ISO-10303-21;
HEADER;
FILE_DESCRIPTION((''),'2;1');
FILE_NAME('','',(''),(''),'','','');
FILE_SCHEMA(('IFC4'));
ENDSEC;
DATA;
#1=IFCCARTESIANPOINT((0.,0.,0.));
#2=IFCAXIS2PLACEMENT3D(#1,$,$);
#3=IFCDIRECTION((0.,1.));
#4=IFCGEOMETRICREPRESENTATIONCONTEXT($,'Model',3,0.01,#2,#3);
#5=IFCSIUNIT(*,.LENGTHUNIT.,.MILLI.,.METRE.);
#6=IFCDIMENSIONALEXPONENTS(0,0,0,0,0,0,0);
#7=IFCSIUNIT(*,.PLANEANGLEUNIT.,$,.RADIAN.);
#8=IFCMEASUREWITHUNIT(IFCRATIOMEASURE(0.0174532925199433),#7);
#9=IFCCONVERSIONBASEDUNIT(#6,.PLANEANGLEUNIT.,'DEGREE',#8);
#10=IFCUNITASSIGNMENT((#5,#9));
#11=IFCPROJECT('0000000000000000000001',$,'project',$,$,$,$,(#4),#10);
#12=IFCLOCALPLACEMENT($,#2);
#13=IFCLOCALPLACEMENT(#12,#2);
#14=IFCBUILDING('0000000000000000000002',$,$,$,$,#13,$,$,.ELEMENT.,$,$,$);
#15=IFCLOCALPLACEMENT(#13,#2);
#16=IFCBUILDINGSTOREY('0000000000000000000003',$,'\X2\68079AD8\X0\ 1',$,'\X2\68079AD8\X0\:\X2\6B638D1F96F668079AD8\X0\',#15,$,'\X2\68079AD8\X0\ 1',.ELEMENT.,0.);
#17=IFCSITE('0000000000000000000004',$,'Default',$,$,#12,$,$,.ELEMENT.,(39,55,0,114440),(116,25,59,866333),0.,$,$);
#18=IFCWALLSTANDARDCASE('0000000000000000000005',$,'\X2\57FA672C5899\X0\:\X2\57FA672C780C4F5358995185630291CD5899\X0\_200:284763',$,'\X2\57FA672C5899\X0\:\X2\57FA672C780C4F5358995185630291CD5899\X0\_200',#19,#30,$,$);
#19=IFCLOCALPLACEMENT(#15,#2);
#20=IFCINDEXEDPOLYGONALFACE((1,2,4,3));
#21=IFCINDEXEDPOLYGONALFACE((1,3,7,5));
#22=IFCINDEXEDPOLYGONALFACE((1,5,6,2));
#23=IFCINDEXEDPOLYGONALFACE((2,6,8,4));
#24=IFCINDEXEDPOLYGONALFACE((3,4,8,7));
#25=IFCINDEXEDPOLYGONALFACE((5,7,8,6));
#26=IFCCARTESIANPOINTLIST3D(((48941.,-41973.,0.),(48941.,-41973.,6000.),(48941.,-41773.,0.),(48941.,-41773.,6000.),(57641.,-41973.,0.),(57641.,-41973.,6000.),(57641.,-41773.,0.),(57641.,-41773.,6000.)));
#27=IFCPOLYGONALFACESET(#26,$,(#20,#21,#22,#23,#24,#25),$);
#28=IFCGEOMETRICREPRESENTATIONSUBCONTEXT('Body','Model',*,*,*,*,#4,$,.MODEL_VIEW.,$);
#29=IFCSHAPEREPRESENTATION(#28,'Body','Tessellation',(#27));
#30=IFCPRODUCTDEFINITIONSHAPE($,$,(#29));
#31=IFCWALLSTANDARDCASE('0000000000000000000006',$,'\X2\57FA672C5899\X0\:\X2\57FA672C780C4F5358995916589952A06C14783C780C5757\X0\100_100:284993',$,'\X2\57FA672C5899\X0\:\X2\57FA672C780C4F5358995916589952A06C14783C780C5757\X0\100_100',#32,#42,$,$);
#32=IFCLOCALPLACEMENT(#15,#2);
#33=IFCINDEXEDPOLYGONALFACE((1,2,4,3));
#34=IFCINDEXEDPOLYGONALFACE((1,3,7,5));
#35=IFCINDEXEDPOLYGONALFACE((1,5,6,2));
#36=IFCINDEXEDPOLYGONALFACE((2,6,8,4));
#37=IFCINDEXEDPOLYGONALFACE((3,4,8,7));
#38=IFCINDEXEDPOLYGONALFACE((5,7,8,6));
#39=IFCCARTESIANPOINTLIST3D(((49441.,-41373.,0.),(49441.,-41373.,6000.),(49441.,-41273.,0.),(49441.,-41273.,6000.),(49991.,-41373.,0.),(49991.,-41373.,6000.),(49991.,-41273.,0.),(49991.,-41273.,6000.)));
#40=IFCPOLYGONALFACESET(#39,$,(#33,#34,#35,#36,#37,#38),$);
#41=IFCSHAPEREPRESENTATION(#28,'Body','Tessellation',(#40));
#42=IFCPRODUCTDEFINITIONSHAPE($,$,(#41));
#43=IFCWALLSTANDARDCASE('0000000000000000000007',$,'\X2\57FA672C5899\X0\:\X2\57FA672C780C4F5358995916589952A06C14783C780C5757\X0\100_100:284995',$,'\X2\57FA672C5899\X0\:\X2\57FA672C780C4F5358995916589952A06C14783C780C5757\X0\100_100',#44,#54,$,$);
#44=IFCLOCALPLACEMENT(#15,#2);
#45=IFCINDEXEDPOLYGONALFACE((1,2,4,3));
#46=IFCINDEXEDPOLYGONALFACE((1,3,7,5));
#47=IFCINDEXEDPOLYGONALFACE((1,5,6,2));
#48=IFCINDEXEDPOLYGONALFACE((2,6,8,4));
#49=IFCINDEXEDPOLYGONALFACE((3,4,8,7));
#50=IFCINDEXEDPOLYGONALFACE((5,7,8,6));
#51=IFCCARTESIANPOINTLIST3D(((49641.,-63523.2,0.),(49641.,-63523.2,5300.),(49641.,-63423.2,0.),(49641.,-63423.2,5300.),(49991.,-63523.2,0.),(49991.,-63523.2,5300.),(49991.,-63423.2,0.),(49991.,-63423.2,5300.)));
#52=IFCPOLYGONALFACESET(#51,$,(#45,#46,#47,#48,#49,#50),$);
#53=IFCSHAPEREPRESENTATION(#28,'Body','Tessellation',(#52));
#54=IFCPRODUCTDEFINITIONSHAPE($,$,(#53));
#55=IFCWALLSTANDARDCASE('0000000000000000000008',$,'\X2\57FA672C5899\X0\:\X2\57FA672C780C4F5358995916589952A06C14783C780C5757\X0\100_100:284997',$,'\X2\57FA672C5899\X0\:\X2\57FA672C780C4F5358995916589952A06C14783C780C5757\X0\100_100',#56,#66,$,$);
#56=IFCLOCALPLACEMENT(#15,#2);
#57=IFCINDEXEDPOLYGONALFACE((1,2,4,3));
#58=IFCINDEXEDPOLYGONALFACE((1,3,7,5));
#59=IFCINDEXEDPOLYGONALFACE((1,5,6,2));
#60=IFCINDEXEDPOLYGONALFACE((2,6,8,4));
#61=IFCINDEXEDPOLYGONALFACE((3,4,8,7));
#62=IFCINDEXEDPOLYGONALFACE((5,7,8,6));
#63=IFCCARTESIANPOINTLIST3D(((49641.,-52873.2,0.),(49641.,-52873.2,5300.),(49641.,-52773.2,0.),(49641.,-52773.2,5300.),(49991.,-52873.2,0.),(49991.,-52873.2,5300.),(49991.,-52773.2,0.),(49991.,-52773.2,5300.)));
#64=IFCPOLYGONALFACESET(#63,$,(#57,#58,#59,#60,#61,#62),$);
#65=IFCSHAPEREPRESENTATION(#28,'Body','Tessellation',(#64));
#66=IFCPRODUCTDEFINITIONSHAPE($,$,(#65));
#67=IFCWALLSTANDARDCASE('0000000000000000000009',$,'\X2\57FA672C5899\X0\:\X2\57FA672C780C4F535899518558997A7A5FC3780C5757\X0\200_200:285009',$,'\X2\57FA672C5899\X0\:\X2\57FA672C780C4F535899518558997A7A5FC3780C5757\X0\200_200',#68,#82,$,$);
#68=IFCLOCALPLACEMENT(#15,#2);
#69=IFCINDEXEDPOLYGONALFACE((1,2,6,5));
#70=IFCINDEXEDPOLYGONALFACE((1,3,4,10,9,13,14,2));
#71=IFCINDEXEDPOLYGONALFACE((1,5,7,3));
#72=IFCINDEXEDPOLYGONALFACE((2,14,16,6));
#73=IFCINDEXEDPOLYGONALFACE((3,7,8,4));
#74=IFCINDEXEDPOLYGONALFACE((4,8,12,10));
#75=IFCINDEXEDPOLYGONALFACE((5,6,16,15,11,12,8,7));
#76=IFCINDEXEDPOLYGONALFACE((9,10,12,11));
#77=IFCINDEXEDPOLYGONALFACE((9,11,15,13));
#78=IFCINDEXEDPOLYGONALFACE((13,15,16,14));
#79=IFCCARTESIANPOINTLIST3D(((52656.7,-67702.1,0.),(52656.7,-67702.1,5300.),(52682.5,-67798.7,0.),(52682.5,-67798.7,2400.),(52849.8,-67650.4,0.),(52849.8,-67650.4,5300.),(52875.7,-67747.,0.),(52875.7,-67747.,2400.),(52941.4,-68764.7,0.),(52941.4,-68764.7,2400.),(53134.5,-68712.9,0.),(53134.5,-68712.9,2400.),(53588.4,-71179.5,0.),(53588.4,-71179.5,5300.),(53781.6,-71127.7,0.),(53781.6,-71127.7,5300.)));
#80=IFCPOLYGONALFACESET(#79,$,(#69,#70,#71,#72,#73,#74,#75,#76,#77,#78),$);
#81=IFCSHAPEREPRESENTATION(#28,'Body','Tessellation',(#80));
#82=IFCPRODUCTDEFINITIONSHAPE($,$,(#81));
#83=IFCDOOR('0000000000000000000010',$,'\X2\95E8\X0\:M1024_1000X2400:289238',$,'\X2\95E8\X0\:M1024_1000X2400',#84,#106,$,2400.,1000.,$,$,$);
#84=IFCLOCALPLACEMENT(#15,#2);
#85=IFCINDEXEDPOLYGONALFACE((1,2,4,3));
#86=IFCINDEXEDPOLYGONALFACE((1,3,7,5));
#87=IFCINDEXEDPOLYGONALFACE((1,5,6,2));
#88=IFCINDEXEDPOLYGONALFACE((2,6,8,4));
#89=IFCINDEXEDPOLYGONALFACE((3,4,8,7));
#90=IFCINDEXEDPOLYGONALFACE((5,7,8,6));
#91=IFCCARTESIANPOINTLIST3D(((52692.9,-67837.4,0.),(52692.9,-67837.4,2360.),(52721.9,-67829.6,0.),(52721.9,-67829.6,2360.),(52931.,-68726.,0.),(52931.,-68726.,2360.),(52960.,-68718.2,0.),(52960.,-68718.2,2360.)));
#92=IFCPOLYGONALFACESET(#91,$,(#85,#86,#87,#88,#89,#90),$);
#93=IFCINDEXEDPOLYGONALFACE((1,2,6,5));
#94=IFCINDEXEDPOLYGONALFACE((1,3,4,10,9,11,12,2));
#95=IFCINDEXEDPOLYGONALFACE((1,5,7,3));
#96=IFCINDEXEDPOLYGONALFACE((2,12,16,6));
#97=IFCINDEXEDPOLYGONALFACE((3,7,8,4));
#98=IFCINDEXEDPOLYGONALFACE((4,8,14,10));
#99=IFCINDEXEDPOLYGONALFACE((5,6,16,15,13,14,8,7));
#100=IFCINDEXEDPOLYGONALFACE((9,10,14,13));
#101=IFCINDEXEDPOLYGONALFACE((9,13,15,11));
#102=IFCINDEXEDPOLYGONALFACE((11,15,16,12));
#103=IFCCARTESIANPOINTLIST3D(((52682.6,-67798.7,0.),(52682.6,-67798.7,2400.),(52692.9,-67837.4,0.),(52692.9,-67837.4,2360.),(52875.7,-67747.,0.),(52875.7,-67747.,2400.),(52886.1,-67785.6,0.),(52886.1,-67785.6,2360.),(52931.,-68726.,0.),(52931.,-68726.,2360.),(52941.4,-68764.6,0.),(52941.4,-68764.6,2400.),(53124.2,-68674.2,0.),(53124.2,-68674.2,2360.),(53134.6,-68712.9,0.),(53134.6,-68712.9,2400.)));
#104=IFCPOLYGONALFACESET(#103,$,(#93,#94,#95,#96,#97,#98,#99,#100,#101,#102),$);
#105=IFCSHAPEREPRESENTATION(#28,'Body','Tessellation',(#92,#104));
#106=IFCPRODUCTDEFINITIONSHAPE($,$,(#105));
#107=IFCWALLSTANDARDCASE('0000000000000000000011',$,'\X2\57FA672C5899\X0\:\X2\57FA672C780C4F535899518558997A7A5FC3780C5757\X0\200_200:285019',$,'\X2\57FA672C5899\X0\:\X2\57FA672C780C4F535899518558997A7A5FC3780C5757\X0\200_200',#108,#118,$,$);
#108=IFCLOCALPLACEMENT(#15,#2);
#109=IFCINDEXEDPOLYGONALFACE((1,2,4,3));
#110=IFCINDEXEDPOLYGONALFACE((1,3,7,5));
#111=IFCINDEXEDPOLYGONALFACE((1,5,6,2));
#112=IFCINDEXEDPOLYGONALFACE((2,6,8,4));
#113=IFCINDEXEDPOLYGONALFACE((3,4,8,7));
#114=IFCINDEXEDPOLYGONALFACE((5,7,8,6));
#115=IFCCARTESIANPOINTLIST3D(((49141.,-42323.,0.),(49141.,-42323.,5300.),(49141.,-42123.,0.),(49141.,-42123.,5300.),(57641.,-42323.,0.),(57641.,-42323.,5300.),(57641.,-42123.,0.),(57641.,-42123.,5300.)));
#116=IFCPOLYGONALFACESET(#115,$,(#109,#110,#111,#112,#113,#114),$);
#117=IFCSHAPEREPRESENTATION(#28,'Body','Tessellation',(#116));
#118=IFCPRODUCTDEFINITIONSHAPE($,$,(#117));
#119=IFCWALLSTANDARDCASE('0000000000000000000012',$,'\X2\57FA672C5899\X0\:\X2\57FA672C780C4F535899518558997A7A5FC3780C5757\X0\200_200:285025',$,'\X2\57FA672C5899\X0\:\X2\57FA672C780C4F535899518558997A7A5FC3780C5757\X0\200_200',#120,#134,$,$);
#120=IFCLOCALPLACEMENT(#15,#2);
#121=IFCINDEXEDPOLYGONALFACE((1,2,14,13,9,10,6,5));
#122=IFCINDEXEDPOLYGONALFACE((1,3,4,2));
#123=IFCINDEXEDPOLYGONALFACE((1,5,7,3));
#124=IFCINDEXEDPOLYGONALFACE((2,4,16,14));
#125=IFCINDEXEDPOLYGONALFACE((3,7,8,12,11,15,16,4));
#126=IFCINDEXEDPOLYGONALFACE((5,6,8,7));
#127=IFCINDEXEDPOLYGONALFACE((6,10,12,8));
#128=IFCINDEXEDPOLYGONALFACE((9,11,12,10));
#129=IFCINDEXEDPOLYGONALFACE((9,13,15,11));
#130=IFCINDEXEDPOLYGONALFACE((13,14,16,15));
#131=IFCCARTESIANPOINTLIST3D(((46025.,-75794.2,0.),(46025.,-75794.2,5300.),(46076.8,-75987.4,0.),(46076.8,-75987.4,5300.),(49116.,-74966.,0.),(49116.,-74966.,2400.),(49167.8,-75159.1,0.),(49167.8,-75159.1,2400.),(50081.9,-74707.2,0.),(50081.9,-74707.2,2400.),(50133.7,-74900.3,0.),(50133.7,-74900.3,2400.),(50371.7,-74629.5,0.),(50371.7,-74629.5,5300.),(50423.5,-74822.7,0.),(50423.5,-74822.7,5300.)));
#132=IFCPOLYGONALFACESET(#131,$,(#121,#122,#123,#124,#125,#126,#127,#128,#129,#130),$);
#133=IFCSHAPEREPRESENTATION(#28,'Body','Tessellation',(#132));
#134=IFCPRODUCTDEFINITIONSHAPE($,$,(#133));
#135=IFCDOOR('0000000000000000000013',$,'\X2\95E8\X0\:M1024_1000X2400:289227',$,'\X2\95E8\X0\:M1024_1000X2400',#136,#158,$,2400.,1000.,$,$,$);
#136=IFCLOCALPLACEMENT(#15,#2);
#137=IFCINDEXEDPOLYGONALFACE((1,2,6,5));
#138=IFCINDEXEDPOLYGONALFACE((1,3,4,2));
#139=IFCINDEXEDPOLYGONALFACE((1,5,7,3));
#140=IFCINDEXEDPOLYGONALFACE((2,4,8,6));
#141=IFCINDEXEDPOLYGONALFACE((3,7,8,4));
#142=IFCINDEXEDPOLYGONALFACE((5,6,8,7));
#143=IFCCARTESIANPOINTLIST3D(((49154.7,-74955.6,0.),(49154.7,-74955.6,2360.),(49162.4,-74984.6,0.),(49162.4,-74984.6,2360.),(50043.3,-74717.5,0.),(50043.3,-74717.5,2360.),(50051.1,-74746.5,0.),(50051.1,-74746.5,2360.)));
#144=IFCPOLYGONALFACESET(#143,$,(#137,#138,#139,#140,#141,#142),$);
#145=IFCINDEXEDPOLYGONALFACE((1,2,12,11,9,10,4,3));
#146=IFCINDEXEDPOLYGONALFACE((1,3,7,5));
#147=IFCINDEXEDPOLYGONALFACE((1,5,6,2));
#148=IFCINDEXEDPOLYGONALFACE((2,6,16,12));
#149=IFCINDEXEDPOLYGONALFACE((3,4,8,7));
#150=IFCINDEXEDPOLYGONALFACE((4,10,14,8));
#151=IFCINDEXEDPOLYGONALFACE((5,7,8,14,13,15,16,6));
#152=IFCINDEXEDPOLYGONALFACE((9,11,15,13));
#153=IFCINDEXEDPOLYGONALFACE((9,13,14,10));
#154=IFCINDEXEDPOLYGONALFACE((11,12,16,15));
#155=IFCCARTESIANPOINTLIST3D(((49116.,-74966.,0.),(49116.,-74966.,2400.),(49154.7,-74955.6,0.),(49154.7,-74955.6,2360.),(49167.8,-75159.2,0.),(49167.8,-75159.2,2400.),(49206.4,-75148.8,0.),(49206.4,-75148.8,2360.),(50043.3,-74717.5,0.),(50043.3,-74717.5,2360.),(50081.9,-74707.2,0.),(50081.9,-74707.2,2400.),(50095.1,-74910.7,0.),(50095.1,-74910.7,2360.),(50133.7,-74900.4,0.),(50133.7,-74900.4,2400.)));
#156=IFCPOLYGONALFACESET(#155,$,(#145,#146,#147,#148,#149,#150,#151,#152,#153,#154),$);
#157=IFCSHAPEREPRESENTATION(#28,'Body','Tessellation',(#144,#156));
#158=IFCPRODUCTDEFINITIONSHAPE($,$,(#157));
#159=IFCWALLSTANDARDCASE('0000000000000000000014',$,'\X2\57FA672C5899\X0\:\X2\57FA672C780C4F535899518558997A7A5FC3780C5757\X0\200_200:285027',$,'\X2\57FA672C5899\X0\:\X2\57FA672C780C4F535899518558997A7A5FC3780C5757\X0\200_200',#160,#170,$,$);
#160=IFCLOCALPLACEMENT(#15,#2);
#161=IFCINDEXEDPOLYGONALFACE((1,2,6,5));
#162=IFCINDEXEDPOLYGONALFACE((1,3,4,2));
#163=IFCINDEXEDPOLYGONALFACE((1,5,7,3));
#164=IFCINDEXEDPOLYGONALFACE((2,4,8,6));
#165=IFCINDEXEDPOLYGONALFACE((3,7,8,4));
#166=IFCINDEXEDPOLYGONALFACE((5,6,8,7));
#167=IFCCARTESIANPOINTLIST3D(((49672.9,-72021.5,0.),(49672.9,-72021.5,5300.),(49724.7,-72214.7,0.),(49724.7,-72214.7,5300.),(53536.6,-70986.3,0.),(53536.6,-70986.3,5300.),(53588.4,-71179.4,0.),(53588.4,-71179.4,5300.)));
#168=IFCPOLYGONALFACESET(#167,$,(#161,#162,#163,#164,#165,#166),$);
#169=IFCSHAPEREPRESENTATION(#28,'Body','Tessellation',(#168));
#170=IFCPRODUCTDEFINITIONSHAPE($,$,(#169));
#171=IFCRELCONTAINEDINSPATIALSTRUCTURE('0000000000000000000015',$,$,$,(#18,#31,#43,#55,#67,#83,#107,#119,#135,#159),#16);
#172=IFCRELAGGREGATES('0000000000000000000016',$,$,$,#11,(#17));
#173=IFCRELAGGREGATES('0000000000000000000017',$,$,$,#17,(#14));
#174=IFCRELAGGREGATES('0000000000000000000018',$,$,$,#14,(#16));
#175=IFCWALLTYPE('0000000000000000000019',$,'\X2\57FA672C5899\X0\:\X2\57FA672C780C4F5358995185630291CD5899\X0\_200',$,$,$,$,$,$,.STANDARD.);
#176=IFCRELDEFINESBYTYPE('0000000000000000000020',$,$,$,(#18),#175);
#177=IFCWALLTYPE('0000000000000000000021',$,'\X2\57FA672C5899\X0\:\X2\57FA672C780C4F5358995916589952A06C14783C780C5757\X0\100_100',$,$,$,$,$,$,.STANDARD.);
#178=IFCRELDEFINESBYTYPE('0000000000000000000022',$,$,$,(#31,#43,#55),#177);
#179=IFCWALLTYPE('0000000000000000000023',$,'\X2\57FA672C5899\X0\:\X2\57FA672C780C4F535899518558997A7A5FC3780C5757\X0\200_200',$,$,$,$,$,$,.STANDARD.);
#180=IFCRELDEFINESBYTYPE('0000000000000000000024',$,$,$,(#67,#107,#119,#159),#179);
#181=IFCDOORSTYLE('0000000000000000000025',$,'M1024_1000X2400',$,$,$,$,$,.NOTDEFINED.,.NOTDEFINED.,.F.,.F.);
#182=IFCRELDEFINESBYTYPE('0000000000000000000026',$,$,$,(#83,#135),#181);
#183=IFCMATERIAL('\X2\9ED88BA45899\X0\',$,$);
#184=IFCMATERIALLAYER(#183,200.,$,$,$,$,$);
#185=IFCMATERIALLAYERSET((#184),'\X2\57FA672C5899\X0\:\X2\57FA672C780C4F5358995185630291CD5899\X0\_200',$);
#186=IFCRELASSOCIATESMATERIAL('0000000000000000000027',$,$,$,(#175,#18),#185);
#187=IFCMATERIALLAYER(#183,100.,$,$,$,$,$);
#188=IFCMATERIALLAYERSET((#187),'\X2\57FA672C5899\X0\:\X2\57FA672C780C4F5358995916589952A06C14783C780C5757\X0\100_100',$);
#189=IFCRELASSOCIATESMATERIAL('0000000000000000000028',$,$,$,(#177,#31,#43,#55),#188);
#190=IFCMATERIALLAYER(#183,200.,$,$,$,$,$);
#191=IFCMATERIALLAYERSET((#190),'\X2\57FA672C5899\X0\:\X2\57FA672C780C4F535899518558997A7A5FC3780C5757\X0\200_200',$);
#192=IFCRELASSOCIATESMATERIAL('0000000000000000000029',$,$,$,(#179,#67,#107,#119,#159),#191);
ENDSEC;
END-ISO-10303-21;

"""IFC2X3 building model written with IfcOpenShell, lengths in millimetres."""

from ifc_helpers import new_model, entity, si_unit, converted_unit, direction, frame, frame_2d, origin, place, context, subcontext, project, spatial, polyline, rectangle, outline, extrude, source, transform, mapped, material, layer, layer_set, layer_usage, type_object, type_shapes, element, fill, save


model = new_model("IFC2X3")

# Units and contexts
model_context = context("Model", 3, precision=0.01, world=origin(), true_north=direction((0.0, 1.0)))
body_context = subcontext(model_context, "Body", "Model", "MODEL_VIEW")
ifc_project = project(units=[si_unit("LENGTHUNIT", "METRE", prefix="MILLI"), converted_unit("PLANEANGLEUNIT", "DEGREE", entity("IfcRatioMeasure", 0.0174532925199433), si_unit("PLANEANGLEUNIT", "RADIAN"), dimensions=[0, 0, 0, 0, 0, 0, 0])], contexts=[model_context])

# Site, building, storey
site_placement = place(None, origin())
site = spatial("IfcSite", under=ifc_project, at=site_placement, Name="Default", CompositionType="ELEMENT", RefLatitude=(39, 55, 0, 114440), RefLongitude=(116, 25, 59, 866333), RefElevation=0.0)
building_placement = place(site_placement, origin())
building = spatial("IfcBuilding", under=site, at=building_placement, CompositionType="ELEMENT")
storey_placement = place(building_placement, origin())
storey = spatial("IfcBuildingStorey", under=building, at=storey_placement, Name="标高 1", ObjectType="标高:正负零标高", LongName="标高 1", CompositionType="ELEMENT", Elevation=0.0)

# Walls
ifc_material = material(Name="默认墙")
ifc_layer_1 = layer(ifc_material, 200.0)
ifc_layer_set_1 = layer_set([ifc_layer_1], Name="基本墙:基本砌体墙内挂重墙_200")
wall_type_1 = type_object("IfcWallType", Name="基本墙:基本砌体墙内挂重墙_200", PredefinedType="STANDARD", material=ifc_layer_set_1)
ifc_layer_usage_1 = layer_usage(ifc_layer_set_1, "AXIS2", "NEGATIVE", 100.0)
wall_1_placement = place(building_placement, frame((48941.0, -41873.0, 0.0)))
element("IfcWallStandardCase", 1, at=wall_1_placement, inside=storey, type_object=wall_type_1, material=ifc_layer_usage_1, Name="基本墙:基本砌体墙内挂重墙_200:284763", ObjectType="基本墙:基本砌体墙内挂重墙_200", context=body_context, shape_type="SweptSolid", body=[
    extrude(rectangle(XDim=8700.0, YDim=200.0, at=frame_2d((4350.0, 0.0), x_axis=(-1.0, 0.0))), origin(), (0.0, 0.0, 1.0), 6000.0),
])
ifc_layer_2 = layer(ifc_material, 100.0)
ifc_layer_set_2 = layer_set([ifc_layer_2], Name="基本墙:基本砌体墙外墙加气砼砌块100_100")
ifc_layer_usage_2 = layer_usage(ifc_layer_set_2, "AXIS2", "NEGATIVE", 50.0)
wall_type_2 = type_object("IfcWallType", Name="基本墙:基本砌体墙外墙加气砼砌块100_100", PredefinedType="STANDARD", material=ifc_layer_set_2)
wall_2_placement = place(building_placement, frame((49441.0, -41323.0, 0.0)))
element("IfcWallStandardCase", 2, at=wall_2_placement, inside=storey, type_object=wall_type_2, material=ifc_layer_usage_2, Name="基本墙:基本砌体墙外墙加气砼砌块100_100:284993", ObjectType="基本墙:基本砌体墙外墙加气砼砌块100_100", context=body_context, shape_type="SweptSolid", body=[
    extrude(rectangle(XDim=550.0, YDim=100.0, at=frame_2d((275.0, 0.0), x_axis=(-1.0, 0.0))), origin(), (0.0, 0.0, 1.0), 6000.0),
])
ifc_layer_usage_3 = layer_usage(ifc_layer_set_2, "AXIS2", "NEGATIVE", 50.0)
wall_3_placement = place(building_placement, frame((49641.0, -63473.2, 0.0)))
element("IfcWallStandardCase", 3, at=wall_3_placement, inside=storey, type_object=wall_type_2, material=ifc_layer_usage_3, Name="基本墙:基本砌体墙外墙加气砼砌块100_100:284995", ObjectType="基本墙:基本砌体墙外墙加气砼砌块100_100", context=body_context, shape_type="SweptSolid", body=[
    extrude(rectangle(XDim=350.0, YDim=100.0, at=frame_2d((175.0, 0.0), x_axis=(-1.0, 0.0))), origin(), (0.0, 0.0, 1.0), 5300.0),
])
ifc_layer_usage_4 = layer_usage(ifc_layer_set_2, "AXIS2", "NEGATIVE", 50.0)
wall_4_placement = place(building_placement, frame((49641.0, -52823.2, 0.0)))
element("IfcWallStandardCase", 4, at=wall_4_placement, inside=storey, type_object=wall_type_2, material=ifc_layer_usage_4, Name="基本墙:基本砌体墙外墙加气砼砌块100_100:284997", ObjectType="基本墙:基本砌体墙外墙加气砼砌块100_100", context=body_context, shape_type="SweptSolid", body=[
    extrude(rectangle(XDim=350.0, YDim=100.0, at=frame_2d((175.0, 0.0), x_axis=(-1.0, 0.0))), origin(), (0.0, 0.0, 1.0), 5300.0),
])

# Wall, opening, door
ifc_layer_3 = layer(ifc_material, 200.0)
ifc_layer_set_3 = layer_set([ifc_layer_3], Name="基本墙:基本砌体墙内墙空心砌块200_200")
ifc_layer_usage_5 = layer_usage(ifc_layer_set_3, "AXIS2", "NEGATIVE", 100.0)
wall_type_3 = type_object("IfcWallType", Name="基本墙:基本砌体墙内墙空心砌块200_200", PredefinedType="STANDARD", material=ifc_layer_set_3)
wall_5_placement = place(building_placement, frame((53685.0, -71153.6, 0.0), z_axis=(0.0, 0.0, 1.0), x_axis=(-0.258819, 0.965926, 0.0)))
wall_5 = element("IfcWallStandardCase", 5, at=wall_5_placement, inside=storey, type_object=wall_type_3, material=ifc_layer_usage_5, Name="基本墙:基本砌体墙内墙空心砌块200_200:285009", ObjectType="基本墙:基本砌体墙内墙空心砌块200_200", context=body_context, shape_type="SweptSolid", body=[
    extrude(rectangle(XDim=3600.0, YDim=200.0, at=frame_2d((1800.0, 0.0), x_axis=(-1.0, 0.0))), origin(), (0.0, 0.0, 1.0), 5300.0),
])
opening_1_placement = place(wall_5_placement, frame((2500.0, -100.0, 0.0)))
opening_1 = element("IfcOpeningElement", 6, at=opening_1_placement, cuts=wall_5, ObjectType="Opening", context=body_context, shape_type="SweptSolid", body=[
    extrude(rectangle(XDim=2400.0, YDim=1000.0, at=frame_2d((1200.0, 500.0), x_axis=(1.0, 0.0))), frame((0.0, 0.0, 0.0), z_axis=(0.000007, 1.0, 0.0), x_axis=(0.0, 0.0, 1.0)), (0.0, 0.0, 1.0), 200.0),
])
door_style = type_object("IfcDoorStyle", Name="M1024_1000X2400", ConstructionType="NOTDEFINED", OperationType="NOTDEFINED", ParameterTakesPrecedence=False, Sizeable=False)
shared_shape_1 = source(origin(), body_context, "Body", "SweptSolid", [
    extrude(rectangle(XDim=30.0, YDim=920.0, at=frame_2d((0.0, 0.0), x_axis=(1.0, 0.0))), frame((500.0, -715.0, 0.0), z_axis=(0.0, 0.0, 1.0), x_axis=(0.0, 1.0, 0.0)), (0.0, 0.0, 1.0), 2360.0),
    extrude(outline(polyline([(-1170.0, 460.0), (1190.0, 460.0), (1190.0, 500.0), (-1210.0, 500.0), (-1210.0, -500.0), (1190.0, -500.0), (1190.0, -460.0), (-1170.0, -460.0), (-1170.0, 460.0)])), frame((500.0, -900.0, 1190.0), z_axis=(0.0, 1.0, 0.0), x_axis=(0.0, 0.0, -1.0)), (0.0, 0.0, 1.0), 200.0),
])
type_shapes(door_style, [shared_shape_1])
door_1_placement = place(opening_1_placement, frame((0.0, 900.0, 0.0)))
door_1 = element("IfcDoor", 7, at=door_1_placement, inside=storey, type_object=door_style, Name="门:M1024_1000X2400:289238", ObjectType="门:M1024_1000X2400", OverallHeight=2400.0, OverallWidth=1000.0, context=body_context, shape_type="MappedRepresentation", body=[
    mapped(shared_shape_1, transform((0.0, 0.0, 0.0), scale=1.0)),
])
fill(opening_1, door_1)

# Wall
ifc_layer_usage_6 = layer_usage(ifc_layer_set_3, "AXIS2", "NEGATIVE", 100.0)
wall_6_placement = place(building_placement, frame((49141.0, -42223.0, 0.0)))
element("IfcWallStandardCase", 8, at=wall_6_placement, inside=storey, type_object=wall_type_3, material=ifc_layer_usage_6, Name="基本墙:基本砌体墙内墙空心砌块200_200:285019", ObjectType="基本墙:基本砌体墙内墙空心砌块200_200", context=body_context, shape_type="SweptSolid", body=[
    extrude(rectangle(XDim=8500.0, YDim=200.0, at=frame_2d((4250.0, 0.0), x_axis=(-1.0, 0.0))), origin(), (0.0, 0.0, 1.0), 5300.0),
])

# Wall, opening, door
ifc_layer_usage_7 = layer_usage(ifc_layer_set_3, "AXIS2", "NEGATIVE", 100.0)
wall_7_placement = place(building_placement, frame((46050.9, -75890.8, 0.0), z_axis=(0.0, 0.0, 1.0), x_axis=(0.965926, 0.258819, 0.0)))
wall_7 = element("IfcWallStandardCase", 9, at=wall_7_placement, inside=storey, type_object=wall_type_3, material=ifc_layer_usage_7, Name="基本墙:基本砌体墙内墙空心砌块200_200:285025", ObjectType="基本墙:基本砌体墙内墙空心砌块200_200", context=body_context, shape_type="SweptSolid", body=[
    extrude(rectangle(XDim=4500.0, YDim=200.0, at=frame_2d((2250.0, 0.0), x_axis=(-1.0, 0.0))), origin(), (0.0, 0.0, 1.0), 5300.0),
])
opening_2_placement = place(wall_7_placement, frame((3200.0, -100.0, 0.0)))
opening_2 = element("IfcOpeningElement", 10, at=opening_2_placement, cuts=wall_7, ObjectType="Opening", context=body_context, shape_type="SweptSolid", body=[
    extrude(rectangle(XDim=2400.0, YDim=1000.0, at=frame_2d((1200.0, 500.0), x_axis=(1.0, 0.0))), frame((0.0, 0.0, 0.0), z_axis=(0.000007, 1.0, 0.0), x_axis=(0.0, 0.0, 1.0)), (0.0, 0.0, 1.0), 200.0),
])
door_2_placement = place(opening_2_placement, frame((0.0, 900.0, 0.0)))
door_2 = element("IfcDoor", 11, at=door_2_placement, inside=storey, type_object=door_style, Name="门:M1024_1000X2400:289227", ObjectType="门:M1024_1000X2400", OverallHeight=2400.0, OverallWidth=1000.0, context=body_context, shape_type="MappedRepresentation", body=[
    mapped(shared_shape_1, transform((0.0, 0.0, 0.0), scale=1.0)),
])
fill(opening_2, door_2)

# Wall
ifc_layer_usage_8 = layer_usage(ifc_layer_set_3, "AXIS2", "NEGATIVE", 100.0)
wall_8_placement = place(building_placement, frame((49698.8, -72118.1, 0.0), z_axis=(0.0, 0.0, 1.0), x_axis=(0.965926, 0.258819, 0.0)))
element("IfcWallStandardCase", 12, at=wall_8_placement, inside=storey, type_object=wall_type_3, material=ifc_layer_usage_8, Name="基本墙:基本砌体墙内墙空心砌块200_200:285027", ObjectType="基本墙:基本砌体墙内墙空心砌块200_200", context=body_context, shape_type="SweptSolid", body=[
    extrude(rectangle(XDim=4000.0, YDim=200.0, at=frame_2d((2000.0, 0.0), x_axis=(-1.0, 0.0))), origin(), (0.0, 0.0, 1.0), 5300.0),
])

save(model, "model.ifc")
